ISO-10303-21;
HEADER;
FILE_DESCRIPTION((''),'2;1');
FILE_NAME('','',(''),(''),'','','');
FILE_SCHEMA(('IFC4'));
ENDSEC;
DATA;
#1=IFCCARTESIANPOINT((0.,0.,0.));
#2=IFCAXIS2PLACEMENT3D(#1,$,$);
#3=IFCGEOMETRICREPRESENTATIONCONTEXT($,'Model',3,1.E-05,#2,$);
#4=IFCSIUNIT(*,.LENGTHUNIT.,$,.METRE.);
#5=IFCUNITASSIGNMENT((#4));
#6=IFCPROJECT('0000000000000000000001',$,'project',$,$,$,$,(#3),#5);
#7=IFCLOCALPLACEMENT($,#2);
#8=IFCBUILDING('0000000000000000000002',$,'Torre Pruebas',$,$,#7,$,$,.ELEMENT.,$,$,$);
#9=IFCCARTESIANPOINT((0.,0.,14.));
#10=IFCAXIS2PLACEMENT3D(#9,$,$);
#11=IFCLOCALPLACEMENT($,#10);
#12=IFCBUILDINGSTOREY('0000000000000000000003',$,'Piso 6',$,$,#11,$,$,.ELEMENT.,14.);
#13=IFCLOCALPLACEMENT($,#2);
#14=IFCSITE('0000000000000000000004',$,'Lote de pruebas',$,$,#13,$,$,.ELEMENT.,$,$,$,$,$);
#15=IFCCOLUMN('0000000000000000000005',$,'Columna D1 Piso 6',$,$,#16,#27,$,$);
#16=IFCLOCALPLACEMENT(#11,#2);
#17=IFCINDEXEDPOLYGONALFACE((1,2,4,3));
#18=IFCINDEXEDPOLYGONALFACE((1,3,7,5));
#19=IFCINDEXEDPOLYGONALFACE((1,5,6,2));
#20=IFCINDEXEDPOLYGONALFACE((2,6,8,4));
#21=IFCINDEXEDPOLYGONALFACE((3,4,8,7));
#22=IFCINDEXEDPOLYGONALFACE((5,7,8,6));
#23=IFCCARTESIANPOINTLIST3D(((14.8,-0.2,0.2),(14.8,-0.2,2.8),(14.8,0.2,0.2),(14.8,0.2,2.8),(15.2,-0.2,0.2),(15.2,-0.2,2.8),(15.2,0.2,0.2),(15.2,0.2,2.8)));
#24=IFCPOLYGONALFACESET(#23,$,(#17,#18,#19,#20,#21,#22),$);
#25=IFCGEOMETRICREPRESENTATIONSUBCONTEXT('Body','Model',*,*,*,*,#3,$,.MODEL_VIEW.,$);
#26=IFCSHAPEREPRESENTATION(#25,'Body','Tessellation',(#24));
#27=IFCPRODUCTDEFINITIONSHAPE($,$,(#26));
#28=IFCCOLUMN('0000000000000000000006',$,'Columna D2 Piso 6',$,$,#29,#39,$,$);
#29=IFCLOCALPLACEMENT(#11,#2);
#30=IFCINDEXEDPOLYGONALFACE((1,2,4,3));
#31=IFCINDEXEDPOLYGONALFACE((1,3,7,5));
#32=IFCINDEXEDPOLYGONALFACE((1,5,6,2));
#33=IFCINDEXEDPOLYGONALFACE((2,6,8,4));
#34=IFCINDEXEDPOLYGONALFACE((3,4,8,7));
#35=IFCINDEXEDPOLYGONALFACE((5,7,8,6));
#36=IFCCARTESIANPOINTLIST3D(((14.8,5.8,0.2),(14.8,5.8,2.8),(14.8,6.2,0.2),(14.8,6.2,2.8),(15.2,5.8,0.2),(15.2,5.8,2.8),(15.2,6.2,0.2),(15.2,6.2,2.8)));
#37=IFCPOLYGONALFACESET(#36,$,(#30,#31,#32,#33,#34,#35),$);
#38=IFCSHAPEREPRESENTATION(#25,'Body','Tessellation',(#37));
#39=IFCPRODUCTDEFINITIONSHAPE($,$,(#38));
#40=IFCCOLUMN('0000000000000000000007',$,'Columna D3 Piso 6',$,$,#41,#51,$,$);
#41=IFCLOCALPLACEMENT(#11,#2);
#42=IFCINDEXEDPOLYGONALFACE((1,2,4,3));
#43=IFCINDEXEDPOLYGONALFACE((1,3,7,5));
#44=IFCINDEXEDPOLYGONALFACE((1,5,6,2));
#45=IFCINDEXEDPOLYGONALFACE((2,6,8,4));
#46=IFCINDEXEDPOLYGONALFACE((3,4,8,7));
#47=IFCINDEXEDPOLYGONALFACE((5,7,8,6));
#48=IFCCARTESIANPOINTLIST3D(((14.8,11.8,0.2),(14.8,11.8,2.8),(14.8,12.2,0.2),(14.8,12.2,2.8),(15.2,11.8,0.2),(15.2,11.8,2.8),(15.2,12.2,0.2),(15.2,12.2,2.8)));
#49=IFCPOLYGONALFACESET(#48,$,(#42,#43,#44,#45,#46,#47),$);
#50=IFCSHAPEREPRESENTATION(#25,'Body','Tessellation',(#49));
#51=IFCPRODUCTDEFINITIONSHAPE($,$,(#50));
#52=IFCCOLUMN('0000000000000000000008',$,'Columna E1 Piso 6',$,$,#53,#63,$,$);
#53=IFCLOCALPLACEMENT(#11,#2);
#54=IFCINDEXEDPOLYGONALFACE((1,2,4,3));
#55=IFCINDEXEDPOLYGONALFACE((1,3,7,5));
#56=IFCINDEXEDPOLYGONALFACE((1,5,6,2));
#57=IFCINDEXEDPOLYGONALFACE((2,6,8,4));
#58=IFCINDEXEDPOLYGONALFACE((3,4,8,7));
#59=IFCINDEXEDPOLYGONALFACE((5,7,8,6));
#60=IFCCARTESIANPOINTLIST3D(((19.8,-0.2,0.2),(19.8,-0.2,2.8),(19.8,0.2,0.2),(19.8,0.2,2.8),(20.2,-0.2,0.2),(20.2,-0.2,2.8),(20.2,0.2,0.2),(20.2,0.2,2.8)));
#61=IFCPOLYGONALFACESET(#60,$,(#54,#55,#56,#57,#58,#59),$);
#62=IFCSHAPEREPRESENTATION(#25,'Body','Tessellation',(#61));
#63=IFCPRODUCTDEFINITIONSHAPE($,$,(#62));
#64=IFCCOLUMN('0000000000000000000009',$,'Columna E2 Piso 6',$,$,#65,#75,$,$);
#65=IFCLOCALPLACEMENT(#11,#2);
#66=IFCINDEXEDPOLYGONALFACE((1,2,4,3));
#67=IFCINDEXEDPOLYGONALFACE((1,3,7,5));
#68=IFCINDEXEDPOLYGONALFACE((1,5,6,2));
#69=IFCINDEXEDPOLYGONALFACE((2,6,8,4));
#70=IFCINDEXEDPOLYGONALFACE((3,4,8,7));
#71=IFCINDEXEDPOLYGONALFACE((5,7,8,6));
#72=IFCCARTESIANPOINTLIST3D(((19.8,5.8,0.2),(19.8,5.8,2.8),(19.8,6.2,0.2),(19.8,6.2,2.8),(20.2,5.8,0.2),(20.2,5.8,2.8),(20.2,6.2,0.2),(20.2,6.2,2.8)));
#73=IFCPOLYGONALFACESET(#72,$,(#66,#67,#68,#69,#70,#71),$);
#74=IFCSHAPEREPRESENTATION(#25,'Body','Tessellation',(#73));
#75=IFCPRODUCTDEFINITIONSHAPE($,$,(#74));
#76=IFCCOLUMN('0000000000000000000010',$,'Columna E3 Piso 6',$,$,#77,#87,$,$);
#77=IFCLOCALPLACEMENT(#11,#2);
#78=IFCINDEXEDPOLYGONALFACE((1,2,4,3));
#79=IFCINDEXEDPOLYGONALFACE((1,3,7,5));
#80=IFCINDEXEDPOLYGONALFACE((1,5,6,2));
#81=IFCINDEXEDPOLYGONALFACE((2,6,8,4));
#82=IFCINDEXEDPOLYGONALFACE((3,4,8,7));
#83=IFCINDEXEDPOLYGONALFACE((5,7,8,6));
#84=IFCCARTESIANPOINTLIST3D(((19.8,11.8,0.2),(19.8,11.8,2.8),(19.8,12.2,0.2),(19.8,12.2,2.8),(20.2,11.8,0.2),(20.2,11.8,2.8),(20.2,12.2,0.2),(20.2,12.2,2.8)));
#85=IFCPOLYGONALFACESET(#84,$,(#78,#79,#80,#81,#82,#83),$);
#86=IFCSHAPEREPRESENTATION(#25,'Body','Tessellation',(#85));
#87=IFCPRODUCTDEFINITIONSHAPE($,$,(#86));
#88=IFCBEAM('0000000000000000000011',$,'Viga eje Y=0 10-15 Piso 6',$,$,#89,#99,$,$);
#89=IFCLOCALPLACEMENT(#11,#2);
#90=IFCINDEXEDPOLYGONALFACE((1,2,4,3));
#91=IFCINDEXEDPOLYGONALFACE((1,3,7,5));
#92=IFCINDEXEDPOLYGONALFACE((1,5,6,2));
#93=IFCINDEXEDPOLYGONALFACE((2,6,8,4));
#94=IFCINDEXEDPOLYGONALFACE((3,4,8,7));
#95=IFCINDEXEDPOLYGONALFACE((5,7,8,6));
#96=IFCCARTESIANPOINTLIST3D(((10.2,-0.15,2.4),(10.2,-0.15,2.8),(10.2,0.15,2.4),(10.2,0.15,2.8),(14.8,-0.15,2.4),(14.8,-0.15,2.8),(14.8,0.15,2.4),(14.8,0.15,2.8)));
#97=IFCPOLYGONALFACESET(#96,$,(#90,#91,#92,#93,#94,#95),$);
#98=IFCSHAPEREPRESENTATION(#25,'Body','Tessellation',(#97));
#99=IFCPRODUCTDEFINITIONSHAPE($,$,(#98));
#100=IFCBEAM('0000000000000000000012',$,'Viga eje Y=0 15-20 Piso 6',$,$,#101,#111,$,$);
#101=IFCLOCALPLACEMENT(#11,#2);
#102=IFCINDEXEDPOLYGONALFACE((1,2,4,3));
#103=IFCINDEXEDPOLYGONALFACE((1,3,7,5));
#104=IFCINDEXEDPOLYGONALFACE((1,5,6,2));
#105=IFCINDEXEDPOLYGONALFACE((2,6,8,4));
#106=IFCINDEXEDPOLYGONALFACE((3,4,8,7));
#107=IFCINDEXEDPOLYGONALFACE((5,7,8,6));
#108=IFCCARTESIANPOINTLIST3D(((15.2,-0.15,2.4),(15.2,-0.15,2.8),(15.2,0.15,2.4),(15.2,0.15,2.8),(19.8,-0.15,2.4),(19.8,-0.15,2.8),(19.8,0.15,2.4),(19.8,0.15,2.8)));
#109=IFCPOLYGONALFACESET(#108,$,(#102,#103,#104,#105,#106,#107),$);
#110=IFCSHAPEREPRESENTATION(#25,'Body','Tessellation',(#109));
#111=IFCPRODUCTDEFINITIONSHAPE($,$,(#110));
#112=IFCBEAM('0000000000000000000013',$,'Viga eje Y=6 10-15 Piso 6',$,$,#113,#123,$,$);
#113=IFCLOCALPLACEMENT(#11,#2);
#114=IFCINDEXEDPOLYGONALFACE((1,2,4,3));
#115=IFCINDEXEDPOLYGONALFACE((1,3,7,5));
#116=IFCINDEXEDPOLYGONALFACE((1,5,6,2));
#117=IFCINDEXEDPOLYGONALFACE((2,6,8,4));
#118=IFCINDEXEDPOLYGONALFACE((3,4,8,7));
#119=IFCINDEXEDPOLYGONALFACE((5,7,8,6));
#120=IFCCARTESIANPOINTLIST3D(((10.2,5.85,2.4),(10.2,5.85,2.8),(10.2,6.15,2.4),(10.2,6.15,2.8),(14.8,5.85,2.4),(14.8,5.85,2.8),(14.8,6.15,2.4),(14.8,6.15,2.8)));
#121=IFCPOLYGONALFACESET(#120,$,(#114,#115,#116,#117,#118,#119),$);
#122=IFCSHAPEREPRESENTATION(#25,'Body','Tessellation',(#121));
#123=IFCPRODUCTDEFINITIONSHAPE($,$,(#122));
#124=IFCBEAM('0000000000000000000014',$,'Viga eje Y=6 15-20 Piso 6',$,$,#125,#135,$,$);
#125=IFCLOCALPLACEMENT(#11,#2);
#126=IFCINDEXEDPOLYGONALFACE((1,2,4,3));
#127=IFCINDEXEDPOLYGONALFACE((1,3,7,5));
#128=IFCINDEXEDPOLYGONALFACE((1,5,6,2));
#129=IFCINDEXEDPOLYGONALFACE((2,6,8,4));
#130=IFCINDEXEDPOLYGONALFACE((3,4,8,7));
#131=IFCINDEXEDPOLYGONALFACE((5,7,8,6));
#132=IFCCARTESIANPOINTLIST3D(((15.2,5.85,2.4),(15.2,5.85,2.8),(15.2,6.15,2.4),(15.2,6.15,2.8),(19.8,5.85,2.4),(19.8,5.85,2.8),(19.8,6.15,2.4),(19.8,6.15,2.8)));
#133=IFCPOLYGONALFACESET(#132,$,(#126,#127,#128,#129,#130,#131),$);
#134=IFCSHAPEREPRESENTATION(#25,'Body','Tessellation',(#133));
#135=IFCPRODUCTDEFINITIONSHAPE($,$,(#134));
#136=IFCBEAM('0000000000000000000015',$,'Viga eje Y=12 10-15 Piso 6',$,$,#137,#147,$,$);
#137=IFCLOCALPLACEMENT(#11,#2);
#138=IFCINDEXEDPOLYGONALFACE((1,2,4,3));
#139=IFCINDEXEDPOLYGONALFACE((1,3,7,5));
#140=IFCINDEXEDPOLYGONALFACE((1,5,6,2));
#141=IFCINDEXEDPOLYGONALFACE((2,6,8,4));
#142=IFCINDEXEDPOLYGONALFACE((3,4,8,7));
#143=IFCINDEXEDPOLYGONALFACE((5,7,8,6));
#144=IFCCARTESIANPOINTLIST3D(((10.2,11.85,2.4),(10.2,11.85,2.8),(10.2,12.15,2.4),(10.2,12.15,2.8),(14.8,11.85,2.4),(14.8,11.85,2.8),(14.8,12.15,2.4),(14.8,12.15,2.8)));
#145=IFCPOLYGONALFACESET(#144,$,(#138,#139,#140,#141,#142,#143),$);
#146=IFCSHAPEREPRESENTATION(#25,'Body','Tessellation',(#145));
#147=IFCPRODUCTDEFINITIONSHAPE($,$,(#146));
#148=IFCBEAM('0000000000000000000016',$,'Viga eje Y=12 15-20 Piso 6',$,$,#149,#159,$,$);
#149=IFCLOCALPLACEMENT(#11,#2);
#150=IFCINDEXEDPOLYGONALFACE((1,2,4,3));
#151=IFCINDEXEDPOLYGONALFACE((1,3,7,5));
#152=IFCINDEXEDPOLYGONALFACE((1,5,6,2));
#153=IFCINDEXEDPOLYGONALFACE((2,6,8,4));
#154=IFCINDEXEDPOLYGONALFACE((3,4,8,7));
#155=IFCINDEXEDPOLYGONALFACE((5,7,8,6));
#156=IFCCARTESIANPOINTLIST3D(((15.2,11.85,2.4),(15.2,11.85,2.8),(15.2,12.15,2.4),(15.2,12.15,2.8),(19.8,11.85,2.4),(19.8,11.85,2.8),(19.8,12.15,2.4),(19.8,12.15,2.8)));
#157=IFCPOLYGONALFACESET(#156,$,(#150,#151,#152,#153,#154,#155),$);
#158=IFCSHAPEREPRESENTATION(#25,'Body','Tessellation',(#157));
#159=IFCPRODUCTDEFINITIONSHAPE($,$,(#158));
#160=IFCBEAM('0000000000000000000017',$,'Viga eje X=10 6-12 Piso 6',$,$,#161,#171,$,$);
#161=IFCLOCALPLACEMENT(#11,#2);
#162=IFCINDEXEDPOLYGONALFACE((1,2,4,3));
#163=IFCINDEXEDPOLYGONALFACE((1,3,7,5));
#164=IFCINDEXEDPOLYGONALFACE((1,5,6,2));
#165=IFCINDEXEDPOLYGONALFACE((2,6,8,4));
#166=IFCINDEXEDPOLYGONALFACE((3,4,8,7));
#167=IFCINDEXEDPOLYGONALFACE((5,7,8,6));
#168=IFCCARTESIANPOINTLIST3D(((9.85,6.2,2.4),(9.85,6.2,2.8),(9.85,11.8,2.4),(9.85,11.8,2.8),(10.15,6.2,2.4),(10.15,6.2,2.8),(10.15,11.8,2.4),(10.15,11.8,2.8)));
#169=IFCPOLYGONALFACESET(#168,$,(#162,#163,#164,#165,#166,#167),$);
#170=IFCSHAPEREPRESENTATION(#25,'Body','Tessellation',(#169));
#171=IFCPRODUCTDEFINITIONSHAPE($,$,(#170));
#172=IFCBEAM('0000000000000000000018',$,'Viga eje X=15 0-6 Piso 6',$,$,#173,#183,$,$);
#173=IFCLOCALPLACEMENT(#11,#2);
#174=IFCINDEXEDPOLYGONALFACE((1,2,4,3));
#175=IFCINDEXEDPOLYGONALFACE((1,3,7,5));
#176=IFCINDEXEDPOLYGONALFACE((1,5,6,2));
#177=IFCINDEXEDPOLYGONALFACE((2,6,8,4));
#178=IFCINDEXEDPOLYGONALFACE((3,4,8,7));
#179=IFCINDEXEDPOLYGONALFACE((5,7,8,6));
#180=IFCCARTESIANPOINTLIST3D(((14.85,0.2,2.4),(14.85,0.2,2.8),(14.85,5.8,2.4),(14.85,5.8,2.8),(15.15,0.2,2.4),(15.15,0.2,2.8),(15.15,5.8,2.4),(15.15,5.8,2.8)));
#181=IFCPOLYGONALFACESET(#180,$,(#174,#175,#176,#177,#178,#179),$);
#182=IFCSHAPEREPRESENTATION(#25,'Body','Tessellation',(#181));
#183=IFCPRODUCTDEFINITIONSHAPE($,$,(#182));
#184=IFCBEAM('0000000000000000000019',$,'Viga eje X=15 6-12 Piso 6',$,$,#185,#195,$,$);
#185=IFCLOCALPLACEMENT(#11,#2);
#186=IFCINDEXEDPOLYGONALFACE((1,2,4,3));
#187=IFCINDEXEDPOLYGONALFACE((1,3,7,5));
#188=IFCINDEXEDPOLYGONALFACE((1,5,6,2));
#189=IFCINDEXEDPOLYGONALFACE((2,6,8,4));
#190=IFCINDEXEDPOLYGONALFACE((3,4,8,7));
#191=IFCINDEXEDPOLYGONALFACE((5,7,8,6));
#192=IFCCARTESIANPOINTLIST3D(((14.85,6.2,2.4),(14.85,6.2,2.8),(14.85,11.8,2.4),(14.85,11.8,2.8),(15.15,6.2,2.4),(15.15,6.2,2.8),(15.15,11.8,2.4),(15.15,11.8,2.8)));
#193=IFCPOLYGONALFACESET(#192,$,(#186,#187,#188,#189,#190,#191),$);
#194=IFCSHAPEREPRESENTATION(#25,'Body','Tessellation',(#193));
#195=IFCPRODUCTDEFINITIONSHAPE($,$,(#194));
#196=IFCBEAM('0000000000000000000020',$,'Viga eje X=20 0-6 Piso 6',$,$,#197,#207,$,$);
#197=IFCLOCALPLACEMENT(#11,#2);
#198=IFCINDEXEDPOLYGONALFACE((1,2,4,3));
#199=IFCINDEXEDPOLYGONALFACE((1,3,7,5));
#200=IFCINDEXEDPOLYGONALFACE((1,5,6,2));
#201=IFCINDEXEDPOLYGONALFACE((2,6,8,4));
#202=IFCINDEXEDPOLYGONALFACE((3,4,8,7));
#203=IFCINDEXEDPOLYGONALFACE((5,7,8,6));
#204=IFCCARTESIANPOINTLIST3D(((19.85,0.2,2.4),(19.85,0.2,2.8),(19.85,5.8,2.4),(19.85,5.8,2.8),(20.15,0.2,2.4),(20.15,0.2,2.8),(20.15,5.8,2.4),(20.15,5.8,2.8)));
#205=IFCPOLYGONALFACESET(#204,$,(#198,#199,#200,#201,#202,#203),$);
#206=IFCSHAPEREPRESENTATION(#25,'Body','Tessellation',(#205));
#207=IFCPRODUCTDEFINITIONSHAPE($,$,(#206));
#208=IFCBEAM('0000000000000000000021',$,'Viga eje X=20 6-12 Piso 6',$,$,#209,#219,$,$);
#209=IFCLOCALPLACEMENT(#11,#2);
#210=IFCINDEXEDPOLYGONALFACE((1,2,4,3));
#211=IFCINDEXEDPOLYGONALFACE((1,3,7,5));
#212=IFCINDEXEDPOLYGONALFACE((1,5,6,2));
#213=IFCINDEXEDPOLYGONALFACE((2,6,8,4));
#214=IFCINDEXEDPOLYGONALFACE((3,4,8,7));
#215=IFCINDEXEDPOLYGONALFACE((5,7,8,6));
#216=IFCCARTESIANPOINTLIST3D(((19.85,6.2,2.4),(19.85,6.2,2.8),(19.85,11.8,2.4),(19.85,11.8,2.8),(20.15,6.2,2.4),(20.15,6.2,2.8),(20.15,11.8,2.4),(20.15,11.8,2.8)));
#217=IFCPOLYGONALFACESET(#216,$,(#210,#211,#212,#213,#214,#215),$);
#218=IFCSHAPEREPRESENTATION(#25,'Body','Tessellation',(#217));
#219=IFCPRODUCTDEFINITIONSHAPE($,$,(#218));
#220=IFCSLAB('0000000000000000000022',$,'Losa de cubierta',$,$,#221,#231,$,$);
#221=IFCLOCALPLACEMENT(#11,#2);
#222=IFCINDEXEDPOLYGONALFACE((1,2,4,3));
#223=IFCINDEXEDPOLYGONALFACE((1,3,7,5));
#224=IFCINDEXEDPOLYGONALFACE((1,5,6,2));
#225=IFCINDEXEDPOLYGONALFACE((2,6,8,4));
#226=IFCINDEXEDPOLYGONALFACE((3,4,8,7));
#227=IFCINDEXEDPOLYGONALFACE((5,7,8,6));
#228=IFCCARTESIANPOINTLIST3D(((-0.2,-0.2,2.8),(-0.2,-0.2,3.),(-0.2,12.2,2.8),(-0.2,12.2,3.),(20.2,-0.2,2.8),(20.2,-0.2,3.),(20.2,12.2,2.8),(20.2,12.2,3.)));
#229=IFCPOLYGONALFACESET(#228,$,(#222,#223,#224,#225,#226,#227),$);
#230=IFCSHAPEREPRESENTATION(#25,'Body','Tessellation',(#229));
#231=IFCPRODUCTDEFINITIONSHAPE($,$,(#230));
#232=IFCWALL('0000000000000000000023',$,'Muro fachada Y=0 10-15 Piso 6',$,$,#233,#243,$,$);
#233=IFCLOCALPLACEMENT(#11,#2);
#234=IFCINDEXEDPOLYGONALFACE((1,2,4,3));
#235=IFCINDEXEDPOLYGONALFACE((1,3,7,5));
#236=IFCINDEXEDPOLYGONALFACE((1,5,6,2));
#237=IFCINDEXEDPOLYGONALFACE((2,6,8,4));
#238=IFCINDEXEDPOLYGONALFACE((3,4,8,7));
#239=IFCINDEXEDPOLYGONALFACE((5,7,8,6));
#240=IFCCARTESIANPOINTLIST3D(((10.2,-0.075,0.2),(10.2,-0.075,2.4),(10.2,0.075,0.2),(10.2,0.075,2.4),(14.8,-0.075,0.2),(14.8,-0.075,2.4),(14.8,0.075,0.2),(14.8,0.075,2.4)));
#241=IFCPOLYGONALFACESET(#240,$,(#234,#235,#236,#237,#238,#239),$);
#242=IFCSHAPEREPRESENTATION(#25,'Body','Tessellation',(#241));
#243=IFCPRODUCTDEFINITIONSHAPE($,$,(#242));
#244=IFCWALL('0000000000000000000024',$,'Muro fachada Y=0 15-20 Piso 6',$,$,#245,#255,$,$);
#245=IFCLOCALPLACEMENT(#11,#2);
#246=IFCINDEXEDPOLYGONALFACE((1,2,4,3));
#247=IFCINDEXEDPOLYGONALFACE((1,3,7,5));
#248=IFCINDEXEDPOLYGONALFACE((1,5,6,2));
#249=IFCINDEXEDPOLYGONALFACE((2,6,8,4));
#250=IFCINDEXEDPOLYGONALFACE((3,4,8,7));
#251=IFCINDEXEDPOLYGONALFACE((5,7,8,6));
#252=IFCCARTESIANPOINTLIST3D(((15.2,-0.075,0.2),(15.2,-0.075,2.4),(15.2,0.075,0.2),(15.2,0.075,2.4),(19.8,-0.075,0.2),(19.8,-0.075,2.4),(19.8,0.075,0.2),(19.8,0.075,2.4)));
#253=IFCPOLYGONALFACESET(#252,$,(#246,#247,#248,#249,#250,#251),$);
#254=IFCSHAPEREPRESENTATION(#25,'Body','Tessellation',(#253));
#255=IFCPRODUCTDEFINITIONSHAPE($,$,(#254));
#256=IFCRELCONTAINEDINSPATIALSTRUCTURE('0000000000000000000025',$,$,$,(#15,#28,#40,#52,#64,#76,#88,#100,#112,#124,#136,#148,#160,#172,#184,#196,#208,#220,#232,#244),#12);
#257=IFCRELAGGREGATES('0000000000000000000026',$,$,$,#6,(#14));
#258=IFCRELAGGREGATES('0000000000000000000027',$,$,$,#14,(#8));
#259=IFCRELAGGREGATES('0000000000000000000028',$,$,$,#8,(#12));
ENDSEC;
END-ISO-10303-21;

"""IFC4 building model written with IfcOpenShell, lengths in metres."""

from ifc_helpers import new_model, si_unit, frame, origin, origin_2d, place, context, subcontext, project, spatial, rectangle, extrude, element, save


model = new_model("IFC4")

# Units and contexts
model_context = context("Model", 3, precision=1e-05, world=origin())
body_context = subcontext(model_context, "Body", "Model", "MODEL_VIEW")
ifc_project = project(units=[si_unit("LENGTHUNIT", "METRE")], contexts=[model_context])

# Site, building, storey
site_placement = place(None, origin())
site = spatial("IfcSite", under=ifc_project, at=site_placement, Name="Lote de pruebas", CompositionType="ELEMENT")
building_placement = place(None, origin())
building = spatial("IfcBuilding", under=site, at=building_placement, Name="Torre Pruebas", CompositionType="ELEMENT")
storey_placement = place(None, frame((0.0, 0.0, 14.0)))
storey = spatial("IfcBuildingStorey", under=building, at=storey_placement, Name="Piso 6", CompositionType="ELEMENT", Elevation=14.0)

# Columns
for number, where, name in (
    (1, (15.0, 0.0, 14.2), "Columna D1 Piso 6"),
    (2, (15.0, 6.0, 14.2), "Columna D2 Piso 6"),
    (3, (15.0, 12.0, 14.2), "Columna D3 Piso 6"),
    (4, (20.0, 0.0, 14.2), "Columna E1 Piso 6"),
    (5, (20.0, 6.0, 14.2), "Columna E2 Piso 6"),
    (6, (20.0, 12.0, 14.2), "Columna E3 Piso 6"),
):
    element("IfcColumn", number, at=place(None, frame(where)), inside=storey, Name=name, context=body_context, shape_type="SweptSolid", body=[
        extrude(rectangle(XDim=0.4, YDim=0.4, at=origin_2d()), origin(), (0.0, 0.0, 1.0), 2.6),
    ])

# Beams
for number, where, name in (
    (7, (12.5, 0.0, 16.4), "Viga eje Y=0 10-15 Piso 6"),
    (8, (17.5, 0.0, 16.4), "Viga eje Y=0 15-20 Piso 6"),
    (9, (12.5, 6.0, 16.4), "Viga eje Y=6 10-15 Piso 6"),
    (10, (17.5, 6.0, 16.4), "Viga eje Y=6 15-20 Piso 6"),
    (11, (12.5, 12.0, 16.4), "Viga eje Y=12 10-15 Piso 6"),
    (12, (17.5, 12.0, 16.4), "Viga eje Y=12 15-20 Piso 6"),
):
    element("IfcBeam", number, at=place(None, frame(where)), inside=storey, Name=name, context=body_context, shape_type="SweptSolid", body=[
        extrude(rectangle(XDim=4.6, YDim=0.3, at=origin_2d()), origin(), (0.0, 0.0, 1.0), 0.4),
    ])
for number, where, name in (
    (13, (10.0, 9.0, 16.4), "Viga eje X=10 6-12 Piso 6"),
    (14, (15.0, 3.0, 16.4), "Viga eje X=15 0-6 Piso 6"),
    (15, (15.0, 9.0, 16.4), "Viga eje X=15 6-12 Piso 6"),
    (16, (20.0, 3.0, 16.4), "Viga eje X=20 0-6 Piso 6"),
    (17, (20.0, 9.0, 16.4), "Viga eje X=20 6-12 Piso 6"),
):
    element("IfcBeam", number, at=place(None, frame(where)), inside=storey, Name=name, context=body_context, shape_type="SweptSolid", body=[
        extrude(rectangle(XDim=0.3, YDim=5.6, at=origin_2d()), origin(), (0.0, 0.0, 1.0), 0.4),
    ])

# Slab
slab_placement = place(None, frame((10.0, 6.0, 16.8)))
element("IfcSlab", 18, at=slab_placement, inside=storey, Name="Losa de cubierta", context=body_context, shape_type="SweptSolid", body=[
    extrude(rectangle(XDim=20.4, YDim=12.4, at=origin_2d()), origin(), (0.0, 0.0, 1.0), 0.2),
])

# Walls
for number, where, name in (
    (19, (12.5, 0.0, 14.2), "Muro fachada Y=0 10-15 Piso 6"),
    (20, (17.5, 0.0, 14.2), "Muro fachada Y=0 15-20 Piso 6"),
):
    element("IfcWall", number, at=place(None, frame(where)), inside=storey, Name=name, context=body_context, shape_type="SweptSolid", body=[
        extrude(rectangle(XDim=4.6, YDim=0.15, at=origin_2d()), origin(), (0.0, 0.0, 1.0), 2.2),
    ])

save(model, "model.ifc")
